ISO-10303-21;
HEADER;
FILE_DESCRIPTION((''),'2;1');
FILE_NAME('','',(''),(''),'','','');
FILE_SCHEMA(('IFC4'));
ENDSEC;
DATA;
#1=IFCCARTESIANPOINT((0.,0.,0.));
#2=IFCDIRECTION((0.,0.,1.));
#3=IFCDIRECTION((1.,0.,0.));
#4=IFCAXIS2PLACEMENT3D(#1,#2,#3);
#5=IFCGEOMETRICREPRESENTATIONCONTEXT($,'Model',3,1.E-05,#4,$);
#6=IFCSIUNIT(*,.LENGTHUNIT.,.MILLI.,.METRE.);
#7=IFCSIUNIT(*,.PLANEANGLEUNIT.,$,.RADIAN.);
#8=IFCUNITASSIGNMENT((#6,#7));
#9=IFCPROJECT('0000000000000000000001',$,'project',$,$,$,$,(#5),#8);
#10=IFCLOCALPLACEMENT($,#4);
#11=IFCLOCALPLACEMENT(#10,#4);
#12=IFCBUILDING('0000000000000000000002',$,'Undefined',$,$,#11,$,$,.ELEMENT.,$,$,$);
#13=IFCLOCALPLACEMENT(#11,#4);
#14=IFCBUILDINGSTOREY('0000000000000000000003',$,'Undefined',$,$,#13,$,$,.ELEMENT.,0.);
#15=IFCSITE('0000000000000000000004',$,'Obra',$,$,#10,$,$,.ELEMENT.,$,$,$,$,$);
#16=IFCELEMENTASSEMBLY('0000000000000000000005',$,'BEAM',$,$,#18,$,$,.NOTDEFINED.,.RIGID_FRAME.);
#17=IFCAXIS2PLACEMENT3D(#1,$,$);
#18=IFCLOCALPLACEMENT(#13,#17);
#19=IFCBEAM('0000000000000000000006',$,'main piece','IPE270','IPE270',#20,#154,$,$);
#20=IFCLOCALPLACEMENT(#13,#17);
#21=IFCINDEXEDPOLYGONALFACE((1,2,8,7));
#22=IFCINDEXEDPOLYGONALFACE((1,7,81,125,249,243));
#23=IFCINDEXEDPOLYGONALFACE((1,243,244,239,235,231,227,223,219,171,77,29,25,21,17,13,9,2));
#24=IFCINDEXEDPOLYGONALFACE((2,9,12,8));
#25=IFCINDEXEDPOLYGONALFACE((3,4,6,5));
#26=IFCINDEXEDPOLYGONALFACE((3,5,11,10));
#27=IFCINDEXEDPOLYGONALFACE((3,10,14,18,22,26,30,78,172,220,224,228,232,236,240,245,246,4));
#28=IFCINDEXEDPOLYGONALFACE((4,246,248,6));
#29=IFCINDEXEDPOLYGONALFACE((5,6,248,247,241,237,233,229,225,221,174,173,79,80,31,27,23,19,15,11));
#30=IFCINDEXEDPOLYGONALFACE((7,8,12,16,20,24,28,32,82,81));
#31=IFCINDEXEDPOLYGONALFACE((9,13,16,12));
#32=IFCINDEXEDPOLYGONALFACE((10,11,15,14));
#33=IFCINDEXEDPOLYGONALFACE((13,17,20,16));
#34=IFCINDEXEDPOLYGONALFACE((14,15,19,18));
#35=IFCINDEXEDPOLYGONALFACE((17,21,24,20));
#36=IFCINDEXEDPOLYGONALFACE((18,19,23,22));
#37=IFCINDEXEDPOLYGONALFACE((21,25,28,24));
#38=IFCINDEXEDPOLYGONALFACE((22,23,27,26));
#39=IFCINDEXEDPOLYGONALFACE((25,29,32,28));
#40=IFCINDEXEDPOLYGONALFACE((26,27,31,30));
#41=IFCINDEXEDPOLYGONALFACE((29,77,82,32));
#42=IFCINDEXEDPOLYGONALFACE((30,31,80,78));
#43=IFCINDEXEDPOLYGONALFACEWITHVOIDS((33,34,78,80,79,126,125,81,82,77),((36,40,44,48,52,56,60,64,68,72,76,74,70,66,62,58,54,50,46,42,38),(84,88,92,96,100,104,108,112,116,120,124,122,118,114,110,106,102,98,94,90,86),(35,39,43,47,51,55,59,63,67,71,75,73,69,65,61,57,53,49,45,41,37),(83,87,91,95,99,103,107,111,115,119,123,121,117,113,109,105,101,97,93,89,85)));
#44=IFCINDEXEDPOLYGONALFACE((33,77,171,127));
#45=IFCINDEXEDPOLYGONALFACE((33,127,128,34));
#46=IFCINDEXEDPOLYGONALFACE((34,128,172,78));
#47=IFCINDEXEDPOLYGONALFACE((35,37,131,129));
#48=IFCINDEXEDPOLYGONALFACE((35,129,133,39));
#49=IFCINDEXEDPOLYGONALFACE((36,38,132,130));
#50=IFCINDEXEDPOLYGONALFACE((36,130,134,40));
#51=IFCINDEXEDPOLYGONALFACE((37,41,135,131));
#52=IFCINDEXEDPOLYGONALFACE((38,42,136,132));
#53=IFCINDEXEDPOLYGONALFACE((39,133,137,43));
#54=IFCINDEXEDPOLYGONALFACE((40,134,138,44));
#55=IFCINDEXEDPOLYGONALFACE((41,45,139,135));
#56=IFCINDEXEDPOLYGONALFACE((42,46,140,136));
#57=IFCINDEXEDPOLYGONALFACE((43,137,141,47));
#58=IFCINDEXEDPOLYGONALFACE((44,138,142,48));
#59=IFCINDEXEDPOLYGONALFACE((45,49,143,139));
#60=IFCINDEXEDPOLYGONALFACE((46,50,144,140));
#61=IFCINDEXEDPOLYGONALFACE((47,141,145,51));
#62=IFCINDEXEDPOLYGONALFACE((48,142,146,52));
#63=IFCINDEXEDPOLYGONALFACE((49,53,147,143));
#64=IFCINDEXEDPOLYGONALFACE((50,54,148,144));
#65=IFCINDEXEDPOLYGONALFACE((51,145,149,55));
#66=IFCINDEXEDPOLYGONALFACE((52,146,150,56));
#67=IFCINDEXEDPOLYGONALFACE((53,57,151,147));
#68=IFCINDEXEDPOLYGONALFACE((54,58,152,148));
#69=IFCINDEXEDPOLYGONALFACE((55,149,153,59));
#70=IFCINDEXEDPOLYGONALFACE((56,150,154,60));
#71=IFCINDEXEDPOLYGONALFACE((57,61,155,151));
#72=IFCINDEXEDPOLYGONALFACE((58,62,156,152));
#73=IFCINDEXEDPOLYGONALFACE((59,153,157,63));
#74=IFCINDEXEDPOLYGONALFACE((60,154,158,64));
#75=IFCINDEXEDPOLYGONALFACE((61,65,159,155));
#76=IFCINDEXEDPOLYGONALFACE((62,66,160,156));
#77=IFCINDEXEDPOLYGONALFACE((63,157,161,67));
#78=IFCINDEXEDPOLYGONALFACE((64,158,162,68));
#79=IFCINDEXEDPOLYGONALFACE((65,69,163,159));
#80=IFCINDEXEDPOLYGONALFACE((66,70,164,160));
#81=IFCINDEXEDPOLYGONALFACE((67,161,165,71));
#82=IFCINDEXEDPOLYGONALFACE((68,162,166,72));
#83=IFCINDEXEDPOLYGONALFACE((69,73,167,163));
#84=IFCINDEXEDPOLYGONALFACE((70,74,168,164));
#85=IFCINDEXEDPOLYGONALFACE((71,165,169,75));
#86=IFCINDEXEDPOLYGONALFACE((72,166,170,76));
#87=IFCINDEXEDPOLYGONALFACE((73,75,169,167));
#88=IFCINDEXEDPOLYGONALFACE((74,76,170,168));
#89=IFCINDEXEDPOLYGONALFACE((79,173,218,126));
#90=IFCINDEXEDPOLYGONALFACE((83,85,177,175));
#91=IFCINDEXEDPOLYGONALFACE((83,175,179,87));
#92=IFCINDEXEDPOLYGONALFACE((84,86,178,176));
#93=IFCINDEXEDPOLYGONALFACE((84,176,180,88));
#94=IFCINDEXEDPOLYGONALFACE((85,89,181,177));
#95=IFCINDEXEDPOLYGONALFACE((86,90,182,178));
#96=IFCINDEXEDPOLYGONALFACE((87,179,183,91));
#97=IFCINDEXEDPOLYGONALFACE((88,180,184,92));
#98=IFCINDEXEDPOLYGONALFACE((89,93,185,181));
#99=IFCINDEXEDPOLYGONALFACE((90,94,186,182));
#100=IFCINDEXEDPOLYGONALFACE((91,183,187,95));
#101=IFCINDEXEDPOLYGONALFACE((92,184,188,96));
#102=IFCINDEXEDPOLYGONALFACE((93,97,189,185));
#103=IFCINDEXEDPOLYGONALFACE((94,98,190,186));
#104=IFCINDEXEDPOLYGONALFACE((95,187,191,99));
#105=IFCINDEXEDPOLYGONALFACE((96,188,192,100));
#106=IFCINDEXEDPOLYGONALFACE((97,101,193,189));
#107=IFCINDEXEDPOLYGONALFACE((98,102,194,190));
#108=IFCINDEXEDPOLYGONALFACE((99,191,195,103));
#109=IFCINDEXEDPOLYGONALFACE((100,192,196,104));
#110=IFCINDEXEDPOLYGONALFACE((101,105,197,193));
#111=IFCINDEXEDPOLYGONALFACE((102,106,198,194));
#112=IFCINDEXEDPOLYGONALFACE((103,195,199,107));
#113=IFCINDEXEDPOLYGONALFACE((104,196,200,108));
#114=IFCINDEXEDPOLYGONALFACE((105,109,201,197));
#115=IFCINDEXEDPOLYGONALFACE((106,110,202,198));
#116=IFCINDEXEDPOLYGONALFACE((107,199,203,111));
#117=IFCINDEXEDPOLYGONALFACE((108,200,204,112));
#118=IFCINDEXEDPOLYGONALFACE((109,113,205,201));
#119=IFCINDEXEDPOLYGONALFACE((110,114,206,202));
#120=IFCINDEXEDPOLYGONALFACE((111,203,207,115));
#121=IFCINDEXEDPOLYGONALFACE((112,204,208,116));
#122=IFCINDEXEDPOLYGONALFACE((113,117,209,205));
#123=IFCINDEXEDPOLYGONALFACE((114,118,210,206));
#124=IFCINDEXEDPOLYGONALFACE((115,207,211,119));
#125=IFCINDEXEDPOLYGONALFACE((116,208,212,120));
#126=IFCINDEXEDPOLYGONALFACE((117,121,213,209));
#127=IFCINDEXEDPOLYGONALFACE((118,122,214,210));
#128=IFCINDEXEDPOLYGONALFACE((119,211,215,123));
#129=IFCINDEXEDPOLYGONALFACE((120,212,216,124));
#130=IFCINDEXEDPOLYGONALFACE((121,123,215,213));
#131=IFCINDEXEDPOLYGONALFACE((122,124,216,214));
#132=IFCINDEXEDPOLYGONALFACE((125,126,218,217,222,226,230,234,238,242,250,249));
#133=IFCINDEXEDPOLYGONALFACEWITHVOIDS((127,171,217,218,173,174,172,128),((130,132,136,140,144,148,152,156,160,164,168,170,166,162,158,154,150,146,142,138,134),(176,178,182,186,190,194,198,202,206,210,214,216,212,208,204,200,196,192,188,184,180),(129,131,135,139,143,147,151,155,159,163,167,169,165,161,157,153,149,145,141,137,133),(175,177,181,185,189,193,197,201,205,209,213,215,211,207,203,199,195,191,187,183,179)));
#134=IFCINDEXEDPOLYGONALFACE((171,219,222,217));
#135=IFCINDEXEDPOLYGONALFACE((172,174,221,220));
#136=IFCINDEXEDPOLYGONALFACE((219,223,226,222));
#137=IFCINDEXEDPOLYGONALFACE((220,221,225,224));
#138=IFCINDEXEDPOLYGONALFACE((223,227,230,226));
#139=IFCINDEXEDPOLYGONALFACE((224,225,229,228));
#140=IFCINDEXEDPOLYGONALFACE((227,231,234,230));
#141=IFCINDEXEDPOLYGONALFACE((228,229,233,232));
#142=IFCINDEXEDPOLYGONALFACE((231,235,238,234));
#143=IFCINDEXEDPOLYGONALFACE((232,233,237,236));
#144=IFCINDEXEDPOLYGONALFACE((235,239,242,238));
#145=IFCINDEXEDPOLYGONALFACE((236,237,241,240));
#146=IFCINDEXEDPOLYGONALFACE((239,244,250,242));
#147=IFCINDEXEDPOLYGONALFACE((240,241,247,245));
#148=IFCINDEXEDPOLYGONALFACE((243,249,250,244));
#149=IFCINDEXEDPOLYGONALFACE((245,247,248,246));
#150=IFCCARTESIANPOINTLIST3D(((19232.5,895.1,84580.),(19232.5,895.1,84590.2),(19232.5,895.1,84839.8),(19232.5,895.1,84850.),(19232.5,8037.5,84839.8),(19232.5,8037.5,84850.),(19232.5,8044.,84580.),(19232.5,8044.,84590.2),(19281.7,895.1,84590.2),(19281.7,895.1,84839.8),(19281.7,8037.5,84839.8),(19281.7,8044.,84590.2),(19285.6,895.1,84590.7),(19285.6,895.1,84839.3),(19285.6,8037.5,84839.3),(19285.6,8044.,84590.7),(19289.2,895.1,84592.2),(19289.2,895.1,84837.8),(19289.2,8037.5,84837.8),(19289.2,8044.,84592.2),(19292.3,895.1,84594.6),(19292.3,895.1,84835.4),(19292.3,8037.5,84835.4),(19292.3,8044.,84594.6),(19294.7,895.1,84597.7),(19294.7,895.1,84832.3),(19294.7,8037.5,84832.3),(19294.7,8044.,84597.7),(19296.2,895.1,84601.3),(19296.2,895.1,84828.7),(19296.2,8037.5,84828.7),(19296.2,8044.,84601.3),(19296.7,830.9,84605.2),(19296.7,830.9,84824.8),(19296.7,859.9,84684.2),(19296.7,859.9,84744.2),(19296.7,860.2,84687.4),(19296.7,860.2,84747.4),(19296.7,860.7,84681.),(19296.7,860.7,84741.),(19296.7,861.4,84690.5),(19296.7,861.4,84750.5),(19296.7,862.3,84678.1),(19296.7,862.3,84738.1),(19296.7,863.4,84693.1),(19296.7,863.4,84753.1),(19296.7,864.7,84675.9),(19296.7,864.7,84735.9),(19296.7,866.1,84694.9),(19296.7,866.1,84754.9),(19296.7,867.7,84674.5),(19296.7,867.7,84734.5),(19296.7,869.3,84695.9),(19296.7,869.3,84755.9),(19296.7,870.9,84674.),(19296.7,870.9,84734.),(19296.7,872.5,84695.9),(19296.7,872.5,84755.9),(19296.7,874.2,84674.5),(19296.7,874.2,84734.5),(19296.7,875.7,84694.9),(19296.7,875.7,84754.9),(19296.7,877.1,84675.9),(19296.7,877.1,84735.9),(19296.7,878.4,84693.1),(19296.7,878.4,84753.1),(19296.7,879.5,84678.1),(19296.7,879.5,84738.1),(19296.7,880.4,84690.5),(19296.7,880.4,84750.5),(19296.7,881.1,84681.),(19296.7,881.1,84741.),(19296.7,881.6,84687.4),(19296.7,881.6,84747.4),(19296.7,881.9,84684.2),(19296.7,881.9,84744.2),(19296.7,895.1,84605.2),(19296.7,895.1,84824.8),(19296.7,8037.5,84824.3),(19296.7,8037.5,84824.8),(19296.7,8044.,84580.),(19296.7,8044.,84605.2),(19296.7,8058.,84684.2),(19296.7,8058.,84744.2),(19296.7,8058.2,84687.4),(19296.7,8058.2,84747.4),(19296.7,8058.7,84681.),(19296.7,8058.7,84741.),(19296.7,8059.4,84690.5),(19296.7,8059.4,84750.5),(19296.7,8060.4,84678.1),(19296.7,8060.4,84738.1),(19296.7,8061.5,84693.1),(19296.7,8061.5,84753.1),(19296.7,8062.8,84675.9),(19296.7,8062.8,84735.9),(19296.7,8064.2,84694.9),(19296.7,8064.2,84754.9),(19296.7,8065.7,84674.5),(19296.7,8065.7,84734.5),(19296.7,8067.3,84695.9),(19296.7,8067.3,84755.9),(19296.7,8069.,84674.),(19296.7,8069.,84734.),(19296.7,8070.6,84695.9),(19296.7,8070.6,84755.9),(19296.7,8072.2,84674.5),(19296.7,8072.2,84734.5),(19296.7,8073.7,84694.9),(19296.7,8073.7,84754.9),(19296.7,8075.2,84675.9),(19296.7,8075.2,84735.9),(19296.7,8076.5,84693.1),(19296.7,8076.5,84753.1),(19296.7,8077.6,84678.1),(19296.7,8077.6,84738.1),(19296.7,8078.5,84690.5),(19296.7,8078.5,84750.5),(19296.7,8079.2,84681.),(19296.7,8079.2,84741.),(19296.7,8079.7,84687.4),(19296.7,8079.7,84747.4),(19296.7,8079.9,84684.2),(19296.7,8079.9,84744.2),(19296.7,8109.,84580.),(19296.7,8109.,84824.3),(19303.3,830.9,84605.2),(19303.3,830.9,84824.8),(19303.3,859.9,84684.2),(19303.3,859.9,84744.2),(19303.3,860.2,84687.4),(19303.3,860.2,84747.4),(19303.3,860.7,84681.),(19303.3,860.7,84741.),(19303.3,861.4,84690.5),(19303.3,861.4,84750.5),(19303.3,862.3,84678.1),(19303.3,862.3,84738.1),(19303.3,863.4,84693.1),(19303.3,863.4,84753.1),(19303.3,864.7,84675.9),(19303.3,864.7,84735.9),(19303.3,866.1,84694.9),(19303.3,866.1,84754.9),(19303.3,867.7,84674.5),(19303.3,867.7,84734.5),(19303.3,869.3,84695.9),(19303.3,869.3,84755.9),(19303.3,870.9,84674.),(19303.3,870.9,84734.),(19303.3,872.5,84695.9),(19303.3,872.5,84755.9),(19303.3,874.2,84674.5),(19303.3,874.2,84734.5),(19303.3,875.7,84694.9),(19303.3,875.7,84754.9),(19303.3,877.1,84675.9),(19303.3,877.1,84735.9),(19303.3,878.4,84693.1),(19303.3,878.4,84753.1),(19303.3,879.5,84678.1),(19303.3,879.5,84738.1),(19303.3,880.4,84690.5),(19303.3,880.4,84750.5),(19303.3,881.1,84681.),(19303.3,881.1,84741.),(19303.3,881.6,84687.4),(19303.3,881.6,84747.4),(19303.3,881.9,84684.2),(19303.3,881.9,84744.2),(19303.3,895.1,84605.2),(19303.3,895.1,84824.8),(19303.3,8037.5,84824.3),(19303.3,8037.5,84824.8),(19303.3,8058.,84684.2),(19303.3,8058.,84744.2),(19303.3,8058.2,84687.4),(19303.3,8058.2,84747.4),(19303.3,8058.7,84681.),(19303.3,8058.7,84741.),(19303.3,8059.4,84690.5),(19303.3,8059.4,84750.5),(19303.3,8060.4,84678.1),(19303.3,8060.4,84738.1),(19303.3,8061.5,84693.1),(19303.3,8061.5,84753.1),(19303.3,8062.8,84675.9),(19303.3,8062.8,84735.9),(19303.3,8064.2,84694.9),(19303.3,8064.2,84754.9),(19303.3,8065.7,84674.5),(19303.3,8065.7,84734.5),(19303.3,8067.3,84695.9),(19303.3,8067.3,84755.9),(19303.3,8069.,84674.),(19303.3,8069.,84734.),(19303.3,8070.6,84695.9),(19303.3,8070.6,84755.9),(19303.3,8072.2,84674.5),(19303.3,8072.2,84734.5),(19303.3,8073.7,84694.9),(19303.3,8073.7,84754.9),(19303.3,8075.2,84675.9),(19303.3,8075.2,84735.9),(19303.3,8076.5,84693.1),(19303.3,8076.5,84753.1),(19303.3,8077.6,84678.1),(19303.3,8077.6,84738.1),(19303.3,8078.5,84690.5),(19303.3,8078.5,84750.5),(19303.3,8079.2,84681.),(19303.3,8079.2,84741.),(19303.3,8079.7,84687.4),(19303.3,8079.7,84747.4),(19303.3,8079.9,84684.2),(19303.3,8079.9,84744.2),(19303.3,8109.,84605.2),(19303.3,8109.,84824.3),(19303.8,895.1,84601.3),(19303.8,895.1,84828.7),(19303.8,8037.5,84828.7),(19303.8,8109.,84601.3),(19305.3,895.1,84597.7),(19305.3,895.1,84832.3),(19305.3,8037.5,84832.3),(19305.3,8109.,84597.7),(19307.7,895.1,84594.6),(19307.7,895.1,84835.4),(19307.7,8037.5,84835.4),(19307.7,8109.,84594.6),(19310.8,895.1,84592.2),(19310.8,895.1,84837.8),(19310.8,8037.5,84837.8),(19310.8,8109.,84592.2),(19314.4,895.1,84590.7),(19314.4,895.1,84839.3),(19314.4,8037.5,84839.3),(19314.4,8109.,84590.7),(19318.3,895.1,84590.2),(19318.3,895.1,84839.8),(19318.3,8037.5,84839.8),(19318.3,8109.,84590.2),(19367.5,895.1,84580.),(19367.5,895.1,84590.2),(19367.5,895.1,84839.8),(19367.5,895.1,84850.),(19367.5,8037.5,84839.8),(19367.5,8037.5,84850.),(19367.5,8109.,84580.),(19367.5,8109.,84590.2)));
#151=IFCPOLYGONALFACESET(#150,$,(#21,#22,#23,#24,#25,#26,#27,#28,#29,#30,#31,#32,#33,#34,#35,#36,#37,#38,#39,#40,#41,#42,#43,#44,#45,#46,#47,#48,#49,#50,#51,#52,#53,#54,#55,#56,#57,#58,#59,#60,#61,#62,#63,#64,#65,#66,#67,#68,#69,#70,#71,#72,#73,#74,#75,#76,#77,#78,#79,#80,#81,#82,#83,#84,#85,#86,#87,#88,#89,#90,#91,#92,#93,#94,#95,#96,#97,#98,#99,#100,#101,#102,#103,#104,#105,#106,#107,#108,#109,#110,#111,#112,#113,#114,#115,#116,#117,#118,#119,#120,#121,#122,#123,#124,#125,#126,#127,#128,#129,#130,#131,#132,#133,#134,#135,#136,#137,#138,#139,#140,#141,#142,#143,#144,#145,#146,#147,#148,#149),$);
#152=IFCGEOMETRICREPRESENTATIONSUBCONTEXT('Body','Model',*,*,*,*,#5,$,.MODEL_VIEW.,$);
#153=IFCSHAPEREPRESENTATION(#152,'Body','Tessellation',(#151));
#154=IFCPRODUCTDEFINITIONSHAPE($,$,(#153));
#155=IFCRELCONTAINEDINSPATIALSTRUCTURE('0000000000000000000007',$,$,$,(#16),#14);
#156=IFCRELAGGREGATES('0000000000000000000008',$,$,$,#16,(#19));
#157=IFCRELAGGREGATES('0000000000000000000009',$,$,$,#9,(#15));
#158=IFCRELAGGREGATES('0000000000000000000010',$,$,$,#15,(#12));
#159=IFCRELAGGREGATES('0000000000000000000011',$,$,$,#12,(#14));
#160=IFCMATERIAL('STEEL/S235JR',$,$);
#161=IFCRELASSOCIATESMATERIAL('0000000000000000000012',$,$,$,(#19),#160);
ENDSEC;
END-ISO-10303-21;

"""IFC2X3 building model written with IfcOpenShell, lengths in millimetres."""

from ifc_helpers import new_model, si_unit, frame, origin_with_axes, origin_2d_with_axis, place, context, subcontext, project, spatial, rectangle, circle, i_section, extrude, clip, halfspace, source, transform, mapped, material, element, aggregate, save


model = new_model("IFC2X3")

# Units and contexts
model_context = context("Model", 3, precision=1e-05, world=origin_with_axes())
body_context = subcontext(model_context, "Body", "Model", "MODEL_VIEW")
ifc_project = project(units=[si_unit("LENGTHUNIT", "METRE", prefix="MILLI"), si_unit("PLANEANGLEUNIT", "RADIAN")], contexts=[model_context])

# Site, building, storey
site_placement = place(None, origin_with_axes())
site = spatial("IfcSite", under=ifc_project, at=site_placement, Name="Obra", CompositionType="ELEMENT")
building_placement = place(site_placement, origin_with_axes())
building = spatial("IfcBuilding", under=site, at=building_placement, Name="Undefined", CompositionType="ELEMENT")
storey_placement = place(building_placement, origin_with_axes())
storey = spatial("IfcBuildingStorey", under=building, at=storey_placement, Name="Undefined", CompositionType="ELEMENT", Elevation=0.0)

# Shared definitions
ifc_material = material(Name="STEEL/S235JR")

# Element assembly, beam, openings
shared_shape_1 = source(origin_with_axes(), body_context, "Body", "SweptSolid", [
    extrude(circle(Radius=11.0, at=origin_2d_with_axis()), frame((0.0, -3.4, 0.0), z_axis=(0.0, 1.0, 0.0), x_axis=(1.0, 0.0, 0.0)), (0.0, 0.0, 1.0), 6.8),
])
assembly_1_placement = place(storey_placement, origin_with_axes())
assembly_1 = element("IfcElementAssembly", 1, at=assembly_1_placement, inside=storey, Name="BEAM", AssemblyPlace="NOTDEFINED", PredefinedType="RIGID_FRAME")
beam_1_placement = place(assembly_1_placement, frame((19300.0, 905.1, 84715.0), z_axis=(0.0, 0.0, 1.0), x_axis=(0.0, 1.0, 0.0)))
beam_1 = element("IfcBeam", 2, at=beam_1_placement, material=ifc_material, Name="main piece", Description="IPE270", ObjectType="IPE270", context=body_context, shape_type="Clipping", body=[
    clip(clip(extrude(i_section(OverallWidth=135.0, OverallDepth=270.0, WebThickness=6.6, FlangeThickness=10.2, FilletRadius=15.0, at=origin_2d_with_axis()), frame((7203.9, 0.0, 0.0), z_axis=(-1.0, 0.0, 0.0), x_axis=(0.0, -1.0, 0.0)), (0.0, 0.0, 1.0), 7278.1), halfspace(frame((7203.9, 0.0, -235.0), z_axis=(-1.0, 0.0, 0.0), x_axis=(0.0, 1.0, 0.0)), True)), halfspace(frame((-74.2, 0.0, -235.0), z_axis=(1.0, 0.0, 0.0), x_axis=(0.0, -1.0, 0.0)), True)),
])
opening_1_placement = place(assembly_1_placement, frame((19300.0, 905.1, 84715.0), z_axis=(0.0, 0.0, 1.0), x_axis=(0.0, 1.0, 0.0)))
element("IfcOpeningElement", 3, at=opening_1_placement, cuts=beam_1, ObjectType="Recess", context=body_context, shape_type="SweptSolid", body=[
    extrude(rectangle(XDim=75.0, YDim=300.0, at=origin_2d_with_axis()), frame((7176.4, 153.3, 124.3), z_axis=(0.0, 0.0, -1.0), x_axis=(-1.0, 0.0, 0.0)), (0.0, 0.0, 1.0), 278.6),
])
opening_2_placement = place(assembly_1_placement, frame((19300.0, 905.1, 84715.0), z_axis=(0.0, 0.0, 1.0), x_axis=(0.0, 1.0, 0.0)))
element("IfcOpeningElement", 4, at=opening_2_placement, cuts=beam_1, ObjectType="Recess", context=body_context, shape_type="SweptSolid", body=[
    extrude(rectangle(XDim=26.7, YDim=83.5, at=origin_2d_with_axis()), frame((7174.1, 68.5, 122.7), z_axis=(0.0, -1.0, 0.0), x_axis=(0.0, 0.0, -1.0)), (0.0, 0.0, 1.0), 137.0),
])
opening_3_placement = place(assembly_1_placement, frame((19300.0, 905.1, 84715.0), z_axis=(0.0, 0.0, 1.0), x_axis=(0.0, 1.0, 0.0)))
element("IfcOpeningElement", 5, at=opening_3_placement, cuts=beam_1, ObjectType="Recess", context=body_context, shape_type="SweptSolid", body=[
    extrude(rectangle(XDim=26.2, YDim=76.2, at=origin_2d_with_axis()), frame((-48.1, -68.5, -122.9), z_axis=(0.0, 1.0, 0.0), x_axis=(0.0, 0.0, -1.0)), (0.0, 0.0, 1.0), 137.0),
])
opening_4_placement = place(assembly_1_placement, frame((19300.0, 905.1, 84715.0), z_axis=(0.0, 0.0, 1.0), x_axis=(0.0, 1.0, 0.0)))
element("IfcOpeningElement", 6, at=opening_4_placement, cuts=beam_1, ObjectType="Recess", context=body_context, shape_type="SweptSolid", body=[
    extrude(rectangle(XDim=26.2, YDim=76.2, at=origin_2d_with_axis()), frame((-48.1, -68.5, 122.9), z_axis=(0.0, 1.0, 0.0), x_axis=(0.0, 0.0, -1.0)), (0.0, 0.0, 1.0), 137.0),
])
opening_5_placement = place(assembly_1_placement, frame((19300.0, 8109.0, 84850.0), z_axis=(0.0, -1.0, 0.0), x_axis=(0.0, 0.0, -1.0)))
element("IfcOpeningElement", 7, at=opening_5_placement, cuts=beam_1, ObjectType="Opening", context=body_context, shape_type="MappedRepresentation", body=[
    mapped(shared_shape_1, transform((105.0, 0.0, 40.0))),
    mapped(shared_shape_1, transform((165.0, 0.0, 40.0))),
])
opening_6_placement = place(assembly_1_placement, frame((19300.0, 830.9, 84850.0), z_axis=(0.0, 1.0, 0.0), x_axis=(0.0, 0.0, -1.0)))
element("IfcOpeningElement", 8, at=opening_6_placement, cuts=beam_1, ObjectType="Opening", context=body_context, shape_type="MappedRepresentation", body=[
    mapped(shared_shape_1, transform((105.0, 0.0, 40.0))),
    mapped(shared_shape_1, transform((165.0, 0.0, 40.0))),
])
aggregate(assembly_1, [beam_1])

save(model, "model.ifc")
